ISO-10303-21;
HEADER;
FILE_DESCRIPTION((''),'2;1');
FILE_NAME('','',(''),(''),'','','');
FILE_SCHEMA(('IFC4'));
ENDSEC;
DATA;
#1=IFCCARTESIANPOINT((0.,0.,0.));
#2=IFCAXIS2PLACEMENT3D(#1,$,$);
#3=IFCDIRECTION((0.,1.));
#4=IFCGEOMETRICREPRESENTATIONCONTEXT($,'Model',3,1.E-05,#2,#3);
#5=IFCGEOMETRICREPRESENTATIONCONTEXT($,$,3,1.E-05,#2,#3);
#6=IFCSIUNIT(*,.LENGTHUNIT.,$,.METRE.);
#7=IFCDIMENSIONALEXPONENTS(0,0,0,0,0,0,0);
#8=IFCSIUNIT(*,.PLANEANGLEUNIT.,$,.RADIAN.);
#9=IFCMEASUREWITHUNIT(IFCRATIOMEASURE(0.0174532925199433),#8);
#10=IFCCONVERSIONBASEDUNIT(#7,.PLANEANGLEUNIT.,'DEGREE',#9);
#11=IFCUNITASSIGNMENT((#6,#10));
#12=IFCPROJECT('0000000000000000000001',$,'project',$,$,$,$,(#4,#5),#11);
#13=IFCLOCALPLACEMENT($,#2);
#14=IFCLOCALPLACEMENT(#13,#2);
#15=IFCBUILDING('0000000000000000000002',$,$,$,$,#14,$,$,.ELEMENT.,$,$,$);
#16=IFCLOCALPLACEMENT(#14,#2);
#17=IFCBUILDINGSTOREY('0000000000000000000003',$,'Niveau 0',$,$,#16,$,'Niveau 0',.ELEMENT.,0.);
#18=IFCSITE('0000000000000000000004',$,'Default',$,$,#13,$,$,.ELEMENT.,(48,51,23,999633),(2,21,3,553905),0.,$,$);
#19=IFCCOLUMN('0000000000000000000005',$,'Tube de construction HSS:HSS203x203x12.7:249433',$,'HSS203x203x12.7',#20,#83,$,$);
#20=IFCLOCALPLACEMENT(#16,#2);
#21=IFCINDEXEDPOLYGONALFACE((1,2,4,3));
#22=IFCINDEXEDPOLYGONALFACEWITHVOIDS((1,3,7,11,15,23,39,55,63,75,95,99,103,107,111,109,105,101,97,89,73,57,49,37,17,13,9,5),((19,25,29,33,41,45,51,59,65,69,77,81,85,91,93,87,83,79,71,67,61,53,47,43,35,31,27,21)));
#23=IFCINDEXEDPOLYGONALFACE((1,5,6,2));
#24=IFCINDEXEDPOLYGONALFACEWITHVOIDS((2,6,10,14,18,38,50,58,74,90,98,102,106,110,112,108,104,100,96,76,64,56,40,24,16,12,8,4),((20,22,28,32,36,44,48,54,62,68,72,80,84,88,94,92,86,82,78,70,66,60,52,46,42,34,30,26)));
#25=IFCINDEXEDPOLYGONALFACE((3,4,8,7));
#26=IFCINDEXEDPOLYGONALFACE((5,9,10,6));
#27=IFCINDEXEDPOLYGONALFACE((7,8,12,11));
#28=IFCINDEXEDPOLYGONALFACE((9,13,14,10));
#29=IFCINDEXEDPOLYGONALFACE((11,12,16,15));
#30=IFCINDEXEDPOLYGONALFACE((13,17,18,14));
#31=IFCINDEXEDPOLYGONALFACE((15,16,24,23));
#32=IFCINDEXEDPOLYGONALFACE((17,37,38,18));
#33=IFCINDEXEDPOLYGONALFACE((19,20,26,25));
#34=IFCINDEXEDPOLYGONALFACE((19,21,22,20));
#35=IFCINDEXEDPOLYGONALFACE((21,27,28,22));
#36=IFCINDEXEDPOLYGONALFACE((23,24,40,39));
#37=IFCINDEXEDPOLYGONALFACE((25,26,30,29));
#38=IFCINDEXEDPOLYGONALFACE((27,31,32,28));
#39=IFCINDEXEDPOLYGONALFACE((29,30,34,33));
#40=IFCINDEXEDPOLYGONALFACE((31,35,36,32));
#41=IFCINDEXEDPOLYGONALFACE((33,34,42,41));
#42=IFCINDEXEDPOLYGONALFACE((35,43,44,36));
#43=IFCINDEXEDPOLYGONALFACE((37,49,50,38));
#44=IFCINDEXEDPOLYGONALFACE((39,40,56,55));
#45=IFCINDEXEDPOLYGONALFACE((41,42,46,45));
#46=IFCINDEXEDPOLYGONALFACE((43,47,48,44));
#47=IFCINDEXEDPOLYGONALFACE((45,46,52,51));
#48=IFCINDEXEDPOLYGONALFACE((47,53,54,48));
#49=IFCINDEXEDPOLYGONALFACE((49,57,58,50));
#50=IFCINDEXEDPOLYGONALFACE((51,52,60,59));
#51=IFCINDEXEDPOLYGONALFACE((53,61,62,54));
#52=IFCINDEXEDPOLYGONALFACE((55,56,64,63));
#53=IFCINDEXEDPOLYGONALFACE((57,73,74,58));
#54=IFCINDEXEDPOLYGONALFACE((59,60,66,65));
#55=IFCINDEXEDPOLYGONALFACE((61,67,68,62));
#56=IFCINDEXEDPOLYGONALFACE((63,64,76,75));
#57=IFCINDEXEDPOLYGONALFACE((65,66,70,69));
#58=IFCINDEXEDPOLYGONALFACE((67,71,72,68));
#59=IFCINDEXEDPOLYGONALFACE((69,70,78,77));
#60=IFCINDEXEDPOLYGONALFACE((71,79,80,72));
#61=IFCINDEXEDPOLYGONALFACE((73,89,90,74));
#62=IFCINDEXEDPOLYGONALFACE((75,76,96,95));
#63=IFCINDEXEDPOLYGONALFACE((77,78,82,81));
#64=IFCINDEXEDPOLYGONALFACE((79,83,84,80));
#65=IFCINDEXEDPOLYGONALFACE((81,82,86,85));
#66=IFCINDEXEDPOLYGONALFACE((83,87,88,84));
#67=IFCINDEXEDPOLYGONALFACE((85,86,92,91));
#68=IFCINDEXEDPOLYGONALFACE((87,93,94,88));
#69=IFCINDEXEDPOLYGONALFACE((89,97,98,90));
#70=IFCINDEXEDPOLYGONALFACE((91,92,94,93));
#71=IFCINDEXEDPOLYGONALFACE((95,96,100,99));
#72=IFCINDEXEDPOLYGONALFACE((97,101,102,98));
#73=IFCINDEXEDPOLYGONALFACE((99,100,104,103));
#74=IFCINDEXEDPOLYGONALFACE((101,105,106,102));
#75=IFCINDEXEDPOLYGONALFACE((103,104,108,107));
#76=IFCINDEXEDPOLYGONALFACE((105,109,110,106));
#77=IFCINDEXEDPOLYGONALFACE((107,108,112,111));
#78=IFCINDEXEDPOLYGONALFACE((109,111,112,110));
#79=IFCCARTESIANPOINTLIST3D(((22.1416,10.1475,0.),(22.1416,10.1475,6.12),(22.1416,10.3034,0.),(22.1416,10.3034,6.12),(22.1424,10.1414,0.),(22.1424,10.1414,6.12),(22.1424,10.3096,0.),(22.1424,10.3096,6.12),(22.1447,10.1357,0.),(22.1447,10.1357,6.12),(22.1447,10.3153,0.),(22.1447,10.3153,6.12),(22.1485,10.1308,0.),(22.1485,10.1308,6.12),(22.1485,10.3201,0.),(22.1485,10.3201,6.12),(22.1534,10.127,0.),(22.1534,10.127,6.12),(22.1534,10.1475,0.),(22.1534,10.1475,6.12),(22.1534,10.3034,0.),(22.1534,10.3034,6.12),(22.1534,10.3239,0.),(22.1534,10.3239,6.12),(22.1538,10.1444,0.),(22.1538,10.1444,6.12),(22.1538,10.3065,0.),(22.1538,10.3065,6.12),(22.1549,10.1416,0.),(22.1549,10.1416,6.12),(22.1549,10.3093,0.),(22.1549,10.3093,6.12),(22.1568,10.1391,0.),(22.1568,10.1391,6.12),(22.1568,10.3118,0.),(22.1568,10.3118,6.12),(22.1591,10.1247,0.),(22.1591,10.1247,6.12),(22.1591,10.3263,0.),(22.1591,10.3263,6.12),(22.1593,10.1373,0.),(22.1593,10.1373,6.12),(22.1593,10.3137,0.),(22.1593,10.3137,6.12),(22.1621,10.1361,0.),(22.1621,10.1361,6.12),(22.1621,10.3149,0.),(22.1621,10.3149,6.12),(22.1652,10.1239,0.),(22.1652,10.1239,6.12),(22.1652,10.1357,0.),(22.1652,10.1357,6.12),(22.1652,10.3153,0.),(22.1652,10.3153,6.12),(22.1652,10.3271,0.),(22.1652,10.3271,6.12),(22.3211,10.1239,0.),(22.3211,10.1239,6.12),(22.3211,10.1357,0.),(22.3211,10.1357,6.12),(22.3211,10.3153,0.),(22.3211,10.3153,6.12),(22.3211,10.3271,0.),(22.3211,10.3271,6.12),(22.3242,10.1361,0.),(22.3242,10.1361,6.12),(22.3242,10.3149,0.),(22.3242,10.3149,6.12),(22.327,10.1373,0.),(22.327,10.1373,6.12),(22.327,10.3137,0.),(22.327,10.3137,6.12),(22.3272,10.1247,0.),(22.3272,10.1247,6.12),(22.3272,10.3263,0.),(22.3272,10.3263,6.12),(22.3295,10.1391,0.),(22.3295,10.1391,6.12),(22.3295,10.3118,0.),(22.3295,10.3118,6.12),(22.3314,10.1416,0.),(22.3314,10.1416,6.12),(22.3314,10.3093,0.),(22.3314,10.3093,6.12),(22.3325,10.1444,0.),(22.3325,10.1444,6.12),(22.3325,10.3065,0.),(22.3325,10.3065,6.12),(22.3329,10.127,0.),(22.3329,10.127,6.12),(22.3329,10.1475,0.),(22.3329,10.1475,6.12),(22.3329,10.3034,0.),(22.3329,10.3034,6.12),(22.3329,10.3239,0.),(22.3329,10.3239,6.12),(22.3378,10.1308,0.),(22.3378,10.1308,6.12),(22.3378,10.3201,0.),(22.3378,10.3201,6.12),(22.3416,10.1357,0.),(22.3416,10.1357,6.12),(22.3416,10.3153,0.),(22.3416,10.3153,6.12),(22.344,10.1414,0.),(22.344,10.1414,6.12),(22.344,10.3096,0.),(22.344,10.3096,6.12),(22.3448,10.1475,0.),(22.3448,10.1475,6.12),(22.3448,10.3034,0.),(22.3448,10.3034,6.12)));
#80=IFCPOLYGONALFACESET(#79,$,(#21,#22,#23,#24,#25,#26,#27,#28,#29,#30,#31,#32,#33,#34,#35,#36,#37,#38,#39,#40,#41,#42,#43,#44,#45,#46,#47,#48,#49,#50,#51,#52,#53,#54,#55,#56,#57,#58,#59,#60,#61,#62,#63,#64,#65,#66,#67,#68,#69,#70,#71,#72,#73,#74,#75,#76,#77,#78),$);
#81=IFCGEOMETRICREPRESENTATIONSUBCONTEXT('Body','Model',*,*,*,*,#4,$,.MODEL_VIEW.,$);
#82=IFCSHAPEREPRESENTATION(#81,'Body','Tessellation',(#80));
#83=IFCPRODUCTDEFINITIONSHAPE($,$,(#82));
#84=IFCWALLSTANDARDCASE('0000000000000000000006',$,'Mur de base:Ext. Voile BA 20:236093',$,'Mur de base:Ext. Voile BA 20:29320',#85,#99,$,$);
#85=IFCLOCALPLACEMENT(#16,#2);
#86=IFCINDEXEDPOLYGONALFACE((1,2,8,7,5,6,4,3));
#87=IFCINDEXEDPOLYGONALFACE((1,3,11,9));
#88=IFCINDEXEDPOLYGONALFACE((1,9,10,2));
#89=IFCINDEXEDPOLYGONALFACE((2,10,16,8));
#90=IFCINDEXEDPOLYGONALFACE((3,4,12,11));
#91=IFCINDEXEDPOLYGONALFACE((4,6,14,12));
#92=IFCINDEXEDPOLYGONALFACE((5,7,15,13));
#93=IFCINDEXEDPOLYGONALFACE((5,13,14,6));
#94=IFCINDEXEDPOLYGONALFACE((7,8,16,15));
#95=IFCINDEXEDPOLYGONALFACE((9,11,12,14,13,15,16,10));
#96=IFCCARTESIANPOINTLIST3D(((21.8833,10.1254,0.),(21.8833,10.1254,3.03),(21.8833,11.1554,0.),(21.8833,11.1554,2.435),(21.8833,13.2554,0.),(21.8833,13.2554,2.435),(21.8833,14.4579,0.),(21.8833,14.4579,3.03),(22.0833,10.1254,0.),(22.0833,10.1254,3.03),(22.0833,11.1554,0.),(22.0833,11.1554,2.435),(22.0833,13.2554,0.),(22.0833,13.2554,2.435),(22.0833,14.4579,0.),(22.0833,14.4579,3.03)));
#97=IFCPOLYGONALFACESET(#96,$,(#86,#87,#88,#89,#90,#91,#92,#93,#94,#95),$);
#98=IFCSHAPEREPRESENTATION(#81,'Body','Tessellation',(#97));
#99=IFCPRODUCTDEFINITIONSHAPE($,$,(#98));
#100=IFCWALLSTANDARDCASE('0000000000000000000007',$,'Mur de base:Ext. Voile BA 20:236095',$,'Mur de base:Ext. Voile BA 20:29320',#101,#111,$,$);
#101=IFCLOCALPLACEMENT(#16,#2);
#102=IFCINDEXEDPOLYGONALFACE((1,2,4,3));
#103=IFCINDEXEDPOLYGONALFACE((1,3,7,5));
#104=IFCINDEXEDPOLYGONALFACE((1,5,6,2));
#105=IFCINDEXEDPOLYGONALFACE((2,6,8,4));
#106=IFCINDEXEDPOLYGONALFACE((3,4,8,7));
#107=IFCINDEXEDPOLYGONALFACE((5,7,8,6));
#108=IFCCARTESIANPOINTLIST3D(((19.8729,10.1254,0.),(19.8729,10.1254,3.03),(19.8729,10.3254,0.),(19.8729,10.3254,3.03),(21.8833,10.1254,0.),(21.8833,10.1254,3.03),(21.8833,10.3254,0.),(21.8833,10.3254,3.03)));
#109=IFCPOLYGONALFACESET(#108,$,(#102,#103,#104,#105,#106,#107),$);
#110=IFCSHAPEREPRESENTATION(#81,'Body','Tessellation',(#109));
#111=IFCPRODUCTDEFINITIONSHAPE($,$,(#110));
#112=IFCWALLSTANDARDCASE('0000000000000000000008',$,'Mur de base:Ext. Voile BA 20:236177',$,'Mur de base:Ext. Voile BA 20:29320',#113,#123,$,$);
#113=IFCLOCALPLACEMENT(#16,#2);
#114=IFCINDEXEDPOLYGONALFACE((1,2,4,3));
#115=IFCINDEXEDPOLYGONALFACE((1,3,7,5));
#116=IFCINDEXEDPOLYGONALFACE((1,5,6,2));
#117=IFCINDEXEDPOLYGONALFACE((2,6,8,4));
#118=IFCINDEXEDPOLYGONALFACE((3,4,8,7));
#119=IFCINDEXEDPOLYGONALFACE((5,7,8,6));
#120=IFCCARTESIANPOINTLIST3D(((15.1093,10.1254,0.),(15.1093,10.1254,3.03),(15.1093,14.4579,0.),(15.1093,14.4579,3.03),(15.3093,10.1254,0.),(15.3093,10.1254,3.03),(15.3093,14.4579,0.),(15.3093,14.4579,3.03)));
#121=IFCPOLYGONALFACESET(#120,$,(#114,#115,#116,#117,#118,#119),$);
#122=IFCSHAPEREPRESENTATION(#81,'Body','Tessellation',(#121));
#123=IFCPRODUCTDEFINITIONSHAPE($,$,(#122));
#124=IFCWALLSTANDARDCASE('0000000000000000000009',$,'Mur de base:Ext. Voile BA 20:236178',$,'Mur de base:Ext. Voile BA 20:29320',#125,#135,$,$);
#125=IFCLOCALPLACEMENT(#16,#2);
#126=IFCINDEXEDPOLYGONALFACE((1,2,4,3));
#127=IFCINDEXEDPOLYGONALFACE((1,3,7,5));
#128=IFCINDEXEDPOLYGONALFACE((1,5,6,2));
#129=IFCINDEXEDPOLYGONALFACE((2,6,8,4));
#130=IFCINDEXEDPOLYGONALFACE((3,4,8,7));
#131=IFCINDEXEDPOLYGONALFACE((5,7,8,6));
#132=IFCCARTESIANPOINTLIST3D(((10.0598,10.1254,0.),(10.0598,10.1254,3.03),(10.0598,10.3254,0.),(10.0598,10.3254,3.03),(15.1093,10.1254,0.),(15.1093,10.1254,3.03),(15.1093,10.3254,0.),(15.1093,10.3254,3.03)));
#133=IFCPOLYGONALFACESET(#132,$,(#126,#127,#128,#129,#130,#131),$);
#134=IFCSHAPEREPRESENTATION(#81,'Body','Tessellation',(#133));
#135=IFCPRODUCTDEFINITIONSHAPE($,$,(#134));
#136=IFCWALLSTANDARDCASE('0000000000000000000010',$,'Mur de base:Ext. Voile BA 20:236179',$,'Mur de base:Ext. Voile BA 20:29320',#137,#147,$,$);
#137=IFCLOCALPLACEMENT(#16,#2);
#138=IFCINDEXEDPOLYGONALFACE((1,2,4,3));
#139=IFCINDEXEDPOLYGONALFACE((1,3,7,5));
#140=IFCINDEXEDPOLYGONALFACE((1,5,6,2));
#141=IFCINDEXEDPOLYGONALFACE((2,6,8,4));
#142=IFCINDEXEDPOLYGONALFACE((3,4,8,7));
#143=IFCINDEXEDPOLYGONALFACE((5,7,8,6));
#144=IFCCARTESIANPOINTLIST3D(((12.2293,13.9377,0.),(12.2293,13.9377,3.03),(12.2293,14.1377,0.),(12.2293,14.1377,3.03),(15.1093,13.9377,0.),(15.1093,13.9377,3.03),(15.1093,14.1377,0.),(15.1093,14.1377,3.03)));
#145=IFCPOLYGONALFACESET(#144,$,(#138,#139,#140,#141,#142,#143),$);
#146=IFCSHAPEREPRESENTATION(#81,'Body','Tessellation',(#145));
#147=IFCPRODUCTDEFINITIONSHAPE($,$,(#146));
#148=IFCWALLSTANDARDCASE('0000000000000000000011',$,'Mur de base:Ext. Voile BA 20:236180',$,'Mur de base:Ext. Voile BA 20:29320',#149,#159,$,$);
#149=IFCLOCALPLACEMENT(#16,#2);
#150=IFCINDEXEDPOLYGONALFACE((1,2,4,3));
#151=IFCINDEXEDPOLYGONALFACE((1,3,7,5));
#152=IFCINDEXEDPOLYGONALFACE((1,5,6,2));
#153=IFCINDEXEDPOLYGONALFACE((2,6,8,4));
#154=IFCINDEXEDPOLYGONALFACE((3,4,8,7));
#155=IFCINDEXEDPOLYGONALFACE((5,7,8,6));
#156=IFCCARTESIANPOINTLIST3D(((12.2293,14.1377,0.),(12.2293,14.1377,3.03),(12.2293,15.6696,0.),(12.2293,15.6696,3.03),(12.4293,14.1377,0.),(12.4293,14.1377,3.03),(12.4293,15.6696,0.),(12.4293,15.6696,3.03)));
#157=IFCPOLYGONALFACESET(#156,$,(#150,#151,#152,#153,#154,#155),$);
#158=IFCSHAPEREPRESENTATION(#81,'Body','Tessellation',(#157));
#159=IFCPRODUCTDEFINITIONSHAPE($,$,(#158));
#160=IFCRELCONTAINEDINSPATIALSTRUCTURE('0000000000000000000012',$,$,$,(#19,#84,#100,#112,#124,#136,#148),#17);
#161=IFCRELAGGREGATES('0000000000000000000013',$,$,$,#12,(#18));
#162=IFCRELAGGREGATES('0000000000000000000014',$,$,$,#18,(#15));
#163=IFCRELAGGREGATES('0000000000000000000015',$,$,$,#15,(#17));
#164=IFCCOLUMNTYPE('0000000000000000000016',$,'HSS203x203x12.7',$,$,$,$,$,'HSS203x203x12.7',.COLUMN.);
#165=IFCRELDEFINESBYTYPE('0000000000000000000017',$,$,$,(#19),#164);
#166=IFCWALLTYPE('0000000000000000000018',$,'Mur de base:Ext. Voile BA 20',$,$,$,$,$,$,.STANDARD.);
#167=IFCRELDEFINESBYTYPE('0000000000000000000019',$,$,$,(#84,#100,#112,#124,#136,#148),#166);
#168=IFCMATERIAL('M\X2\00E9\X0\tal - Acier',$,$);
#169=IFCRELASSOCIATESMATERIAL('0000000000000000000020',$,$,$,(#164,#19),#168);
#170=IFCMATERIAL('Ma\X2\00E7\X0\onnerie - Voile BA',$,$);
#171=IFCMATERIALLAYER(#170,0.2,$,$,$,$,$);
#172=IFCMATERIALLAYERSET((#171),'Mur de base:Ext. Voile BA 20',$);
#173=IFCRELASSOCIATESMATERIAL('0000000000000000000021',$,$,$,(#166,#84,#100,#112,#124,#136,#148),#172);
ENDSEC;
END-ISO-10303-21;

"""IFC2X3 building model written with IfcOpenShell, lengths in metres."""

from ifc_helpers import new_model, entity, si_unit, converted_unit, direction, frame, frame_2d, origin, origin_2d_with_axis, place, context, subcontext, project, spatial, polyline, circle_curve, parameter, trimmed, segment, composite_curve, rectangle, outline, extrude, source, transform, mapped, material, layer, layer_set, layer_usage, type_object, type_shapes, element, save


model = new_model("IFC2X3")

# Units and contexts
model_context = context("Model", 3, precision=1e-05, world=origin(), true_north=direction((0.0, 1.0)))
context_of_model = context(None, 3, precision=1e-05, world=origin(), true_north=direction((0.0, 1.0)))
body_context = subcontext(model_context, "Body", "Model", "MODEL_VIEW")
ifc_project = project(units=[si_unit("LENGTHUNIT", "METRE"), converted_unit("PLANEANGLEUNIT", "DEGREE", entity("IfcRatioMeasure", 0.0174532925199433), si_unit("PLANEANGLEUNIT", "RADIAN"), dimensions=[0, 0, 0, 0, 0, 0, 0])], contexts=[model_context, context_of_model])

# Site, building, storey
site_placement = place(None, origin())
site = spatial("IfcSite", under=ifc_project, at=site_placement, Name="Default", CompositionType="ELEMENT", RefLatitude=(48, 51, 23, 999633), RefLongitude=(2, 21, 3, 553905), RefElevation=0.0)
building_placement = place(site_placement, origin())
building = spatial("IfcBuilding", under=site, at=building_placement, CompositionType="ELEMENT")
storey_placement = place(building_placement, origin())
storey = spatial("IfcBuildingStorey", under=building, at=storey_placement, Name="Niveau 0", LongName="Niveau 0", CompositionType="ELEMENT", Elevation=0.0)

# Column
ifc_material_1 = material(Name="Métal - Acier")
column_type = type_object("IfcColumnType", Name="HSS203x203x12.7", ElementType="HSS203x203x12.7", PredefinedType="COLUMN", material=ifc_material_1)
shared_shape = source(origin(), body_context, "Body", "SweptSolid", [
    extrude(outline(composite_curve([segment(polyline([(-0.078, -0.1016), (0.078, -0.1016)]), True, "CONTINUOUS"), segment(trimmed(circle_curve(frame_2d((0.078, -0.078), x_axis=(-1.0, 0.0)), 0.0236), [parameter(90.0)], [parameter(180.0)], True, "PARAMETER"), True, "CONTINUOUS"), segment(polyline([(0.1016, -0.078), (0.1016, 0.078)]), True, "CONTINUOUS"), segment(trimmed(circle_curve(frame_2d((0.078, 0.078), x_axis=(-1.0, 0.0)), 0.0236), [parameter(180.0)], [parameter(270.0)], True, "PARAMETER"), True, "CONTINUOUS"), segment(polyline([(0.078, 0.1016), (-0.078, 0.1016)]), True, "CONTINUOUS"), segment(trimmed(circle_curve(frame_2d((-0.078, 0.078), x_axis=(-1.0, 0.0)), 0.0236), [parameter(270.0)], [parameter(360.0)], True, "PARAMETER"), True, "CONTINUOUS"), segment(polyline([(-0.1016, 0.078), (-0.1016, -0.078)]), True, "CONTINUOUS"), segment(trimmed(circle_curve(frame_2d((-0.078, -0.078), x_axis=(-1.0, 0.0)), 0.0236), [parameter(360.0)], [parameter(90.0)], True, "PARAMETER"), True, "CONTINUOUS")], self_intersect=False), holes=[composite_curve([segment(trimmed(circle_curve(frame_2d((-0.078, -0.078), x_axis=(-1.0, 0.0)), 0.0118), [parameter(0.0)], [parameter(90.0)], True, "PARAMETER"), False, "CONTINUOUS"), segment(polyline([(-0.0898, -0.078), (-0.0898, 0.078)]), True, "CONTINUOUS"), segment(trimmed(circle_curve(frame_2d((-0.078, 0.078), x_axis=(-1.0, 0.0)), 0.0118), [parameter(270.0)], [parameter(360.0)], True, "PARAMETER"), False, "CONTINUOUS"), segment(polyline([(-0.078, 0.0898), (0.078, 0.0898)]), True, "CONTINUOUS"), segment(trimmed(circle_curve(frame_2d((0.078, 0.078), x_axis=(-1.0, 0.0)), 0.0118), [parameter(180.0)], [parameter(270.0)], True, "PARAMETER"), False, "CONTINUOUS"), segment(polyline([(0.0898, 0.078), (0.0898, -0.078)]), True, "CONTINUOUS"), segment(trimmed(circle_curve(frame_2d((0.078, -0.078), x_axis=(-1.0, 0.0)), 0.0118), [parameter(90.0)], [parameter(180.0)], True, "PARAMETER"), False, "CONTINUOUS"), segment(polyline([(0.078, -0.0898), (-0.078, -0.0898)]), True, "CONTINUOUS")], self_intersect=False)]), frame((0.0, 0.0, 0.0), z_axis=(0.0, 0.0, 1.0), x_axis=(-1.0, 0.0, 0.0)), (0.0, 0.0, 1.0), 6.12),
])
type_shapes(column_type, [shared_shape])
for number, where, name in (
    (1, (22.2432, 10.2255, 0.0), "Tube de construction HSS:HSS203x203x12.7:249433"),
):
    element("IfcColumn", number, at=place(storey_placement, frame(where)), inside=storey, type_object=column_type, material=ifc_material_1, Name=name, ObjectType="HSS203x203x12.7", context=body_context, shape_type="MappedRepresentation", body=[
        mapped(shared_shape, transform((0.0, 0.0, 0.0), scale=1.0)),
    ])

# Wall, opening
ifc_material_2 = material(Name="Maçonnerie - Voile BA")
ifc_layer = layer(ifc_material_2, 0.2)
ifc_layer_set = layer_set([ifc_layer], Name="Mur de base:Ext. Voile BA 20")
ifc_layer_usage_1 = layer_usage(ifc_layer_set, "AXIS2", "NEGATIVE", 0.1)
wall_type = type_object("IfcWallType", Name="Mur de base:Ext. Voile BA 20", PredefinedType="STANDARD", material=ifc_layer_set)
wall_1_placement = place(storey_placement, frame((21.9833, 14.4579, 0.0), z_axis=(0.0, 0.0, 1.0), x_axis=(0.0, -1.0, 0.0)))
wall_1 = element("IfcWallStandardCase", 2, at=wall_1_placement, inside=storey, type_object=wall_type, material=ifc_layer_usage_1, Name="Mur de base:Ext. Voile BA 20:236093", ObjectType="Mur de base:Ext. Voile BA 20:29320", context=body_context, shape_type="SweptSolid", body=[
    extrude(rectangle(XDim=4.3325, YDim=0.2, at=frame_2d((2.1662, 0.0), x_axis=(-1.0, 0.0))), origin(), (0.0, 0.0, 1.0), 3.03),
])
opening_1_placement = place(wall_1_placement, origin())
element("IfcOpeningElement", 3, at=opening_1_placement, cuts=wall_1, ObjectType="Opening", context=body_context, shape_type="SweptSolid", body=[
    extrude(rectangle(XDim=2.465, YDim=2.1, at=origin_2d_with_axis()), frame((2.2525, -0.1, 1.2025), z_axis=(0.0, 1.0, 0.0), x_axis=(0.0, 0.0, -1.0)), (0.0, 0.0, 1.0), 0.2),
])

# Wall
ifc_layer_usage_2 = layer_usage(ifc_layer_set, "AXIS2", "NEGATIVE", 0.1)
wall_2_placement = place(storey_placement, frame((21.8833, 10.2254, 0.0), z_axis=(0.0, 0.0, 1.0), x_axis=(-1.0, 0.0, 0.0)))
element("IfcWallStandardCase", 4, at=wall_2_placement, inside=storey, type_object=wall_type, material=ifc_layer_usage_2, Name="Mur de base:Ext. Voile BA 20:236095", ObjectType="Mur de base:Ext. Voile BA 20:29320", context=body_context, shape_type="SweptSolid", body=[
    extrude(rectangle(XDim=2.0103, YDim=0.2, at=frame_2d((1.0052, 0.0), x_axis=(-1.0, 0.0))), origin(), (0.0, 0.0, 1.0), 3.03),
])

# Walls
ifc_layer_usage_3 = layer_usage(ifc_layer_set, "AXIS2", "NEGATIVE", 0.1)
wall_3_placement = place(storey_placement, frame((15.2093, 14.4579, 0.0), z_axis=(0.0, 0.0, 1.0), x_axis=(0.0, -1.0, 0.0)))
element("IfcWallStandardCase", 5, at=wall_3_placement, inside=storey, type_object=wall_type, material=ifc_layer_usage_3, Name="Mur de base:Ext. Voile BA 20:236177", ObjectType="Mur de base:Ext. Voile BA 20:29320", context=body_context, shape_type="SweptSolid", body=[
    extrude(rectangle(XDim=4.3325, YDim=0.2, at=frame_2d((2.1662, 0.0), x_axis=(-1.0, 0.0))), origin(), (0.0, 0.0, 1.0), 3.03),
])
ifc_layer_usage_4 = layer_usage(ifc_layer_set, "AXIS2", "NEGATIVE", 0.1)
wall_4_placement = place(storey_placement, frame((15.1093, 10.2254, 0.0), z_axis=(0.0, 0.0, 1.0), x_axis=(-1.0, 0.0, 0.0)))
element("IfcWallStandardCase", 6, at=wall_4_placement, inside=storey, type_object=wall_type, material=ifc_layer_usage_4, Name="Mur de base:Ext. Voile BA 20:236178", ObjectType="Mur de base:Ext. Voile BA 20:29320", context=body_context, shape_type="SweptSolid", body=[
    extrude(rectangle(XDim=5.0496, YDim=0.2, at=frame_2d((2.5248, 0.0), x_axis=(-1.0, 0.0))), origin(), (0.0, 0.0, 1.0), 3.03),
])
ifc_layer_usage_5 = layer_usage(ifc_layer_set, "AXIS2", "NEGATIVE", 0.1)
wall_5_placement = place(storey_placement, frame((15.1093, 14.0377, 0.0), z_axis=(0.0, 0.0, 1.0), x_axis=(-1.0, 0.0, 0.0)))
element("IfcWallStandardCase", 7, at=wall_5_placement, inside=storey, type_object=wall_type, material=ifc_layer_usage_5, Name="Mur de base:Ext. Voile BA 20:236179", ObjectType="Mur de base:Ext. Voile BA 20:29320", context=body_context, shape_type="SweptSolid", body=[
    extrude(rectangle(XDim=2.88, YDim=0.2, at=frame_2d((1.44, 0.0), x_axis=(-1.0, 0.0))), origin(), (0.0, 0.0, 1.0), 3.03),
])
ifc_layer_usage_6 = layer_usage(ifc_layer_set, "AXIS2", "NEGATIVE", 0.1)
wall_6_placement = place(storey_placement, frame((12.3293, 14.1377, 0.0), z_axis=(0.0, 0.0, 1.0), x_axis=(0.0, 1.0, 0.0)))
element("IfcWallStandardCase", 8, at=wall_6_placement, inside=storey, type_object=wall_type, material=ifc_layer_usage_6, Name="Mur de base:Ext. Voile BA 20:236180", ObjectType="Mur de base:Ext. Voile BA 20:29320", context=body_context, shape_type="SweptSolid", body=[
    extrude(rectangle(XDim=1.5319, YDim=0.2, at=frame_2d((0.766, 0.0), x_axis=(-1.0, 0.0))), origin(), (0.0, 0.0, 1.0), 3.03),
])

save(model, "model.ifc")
